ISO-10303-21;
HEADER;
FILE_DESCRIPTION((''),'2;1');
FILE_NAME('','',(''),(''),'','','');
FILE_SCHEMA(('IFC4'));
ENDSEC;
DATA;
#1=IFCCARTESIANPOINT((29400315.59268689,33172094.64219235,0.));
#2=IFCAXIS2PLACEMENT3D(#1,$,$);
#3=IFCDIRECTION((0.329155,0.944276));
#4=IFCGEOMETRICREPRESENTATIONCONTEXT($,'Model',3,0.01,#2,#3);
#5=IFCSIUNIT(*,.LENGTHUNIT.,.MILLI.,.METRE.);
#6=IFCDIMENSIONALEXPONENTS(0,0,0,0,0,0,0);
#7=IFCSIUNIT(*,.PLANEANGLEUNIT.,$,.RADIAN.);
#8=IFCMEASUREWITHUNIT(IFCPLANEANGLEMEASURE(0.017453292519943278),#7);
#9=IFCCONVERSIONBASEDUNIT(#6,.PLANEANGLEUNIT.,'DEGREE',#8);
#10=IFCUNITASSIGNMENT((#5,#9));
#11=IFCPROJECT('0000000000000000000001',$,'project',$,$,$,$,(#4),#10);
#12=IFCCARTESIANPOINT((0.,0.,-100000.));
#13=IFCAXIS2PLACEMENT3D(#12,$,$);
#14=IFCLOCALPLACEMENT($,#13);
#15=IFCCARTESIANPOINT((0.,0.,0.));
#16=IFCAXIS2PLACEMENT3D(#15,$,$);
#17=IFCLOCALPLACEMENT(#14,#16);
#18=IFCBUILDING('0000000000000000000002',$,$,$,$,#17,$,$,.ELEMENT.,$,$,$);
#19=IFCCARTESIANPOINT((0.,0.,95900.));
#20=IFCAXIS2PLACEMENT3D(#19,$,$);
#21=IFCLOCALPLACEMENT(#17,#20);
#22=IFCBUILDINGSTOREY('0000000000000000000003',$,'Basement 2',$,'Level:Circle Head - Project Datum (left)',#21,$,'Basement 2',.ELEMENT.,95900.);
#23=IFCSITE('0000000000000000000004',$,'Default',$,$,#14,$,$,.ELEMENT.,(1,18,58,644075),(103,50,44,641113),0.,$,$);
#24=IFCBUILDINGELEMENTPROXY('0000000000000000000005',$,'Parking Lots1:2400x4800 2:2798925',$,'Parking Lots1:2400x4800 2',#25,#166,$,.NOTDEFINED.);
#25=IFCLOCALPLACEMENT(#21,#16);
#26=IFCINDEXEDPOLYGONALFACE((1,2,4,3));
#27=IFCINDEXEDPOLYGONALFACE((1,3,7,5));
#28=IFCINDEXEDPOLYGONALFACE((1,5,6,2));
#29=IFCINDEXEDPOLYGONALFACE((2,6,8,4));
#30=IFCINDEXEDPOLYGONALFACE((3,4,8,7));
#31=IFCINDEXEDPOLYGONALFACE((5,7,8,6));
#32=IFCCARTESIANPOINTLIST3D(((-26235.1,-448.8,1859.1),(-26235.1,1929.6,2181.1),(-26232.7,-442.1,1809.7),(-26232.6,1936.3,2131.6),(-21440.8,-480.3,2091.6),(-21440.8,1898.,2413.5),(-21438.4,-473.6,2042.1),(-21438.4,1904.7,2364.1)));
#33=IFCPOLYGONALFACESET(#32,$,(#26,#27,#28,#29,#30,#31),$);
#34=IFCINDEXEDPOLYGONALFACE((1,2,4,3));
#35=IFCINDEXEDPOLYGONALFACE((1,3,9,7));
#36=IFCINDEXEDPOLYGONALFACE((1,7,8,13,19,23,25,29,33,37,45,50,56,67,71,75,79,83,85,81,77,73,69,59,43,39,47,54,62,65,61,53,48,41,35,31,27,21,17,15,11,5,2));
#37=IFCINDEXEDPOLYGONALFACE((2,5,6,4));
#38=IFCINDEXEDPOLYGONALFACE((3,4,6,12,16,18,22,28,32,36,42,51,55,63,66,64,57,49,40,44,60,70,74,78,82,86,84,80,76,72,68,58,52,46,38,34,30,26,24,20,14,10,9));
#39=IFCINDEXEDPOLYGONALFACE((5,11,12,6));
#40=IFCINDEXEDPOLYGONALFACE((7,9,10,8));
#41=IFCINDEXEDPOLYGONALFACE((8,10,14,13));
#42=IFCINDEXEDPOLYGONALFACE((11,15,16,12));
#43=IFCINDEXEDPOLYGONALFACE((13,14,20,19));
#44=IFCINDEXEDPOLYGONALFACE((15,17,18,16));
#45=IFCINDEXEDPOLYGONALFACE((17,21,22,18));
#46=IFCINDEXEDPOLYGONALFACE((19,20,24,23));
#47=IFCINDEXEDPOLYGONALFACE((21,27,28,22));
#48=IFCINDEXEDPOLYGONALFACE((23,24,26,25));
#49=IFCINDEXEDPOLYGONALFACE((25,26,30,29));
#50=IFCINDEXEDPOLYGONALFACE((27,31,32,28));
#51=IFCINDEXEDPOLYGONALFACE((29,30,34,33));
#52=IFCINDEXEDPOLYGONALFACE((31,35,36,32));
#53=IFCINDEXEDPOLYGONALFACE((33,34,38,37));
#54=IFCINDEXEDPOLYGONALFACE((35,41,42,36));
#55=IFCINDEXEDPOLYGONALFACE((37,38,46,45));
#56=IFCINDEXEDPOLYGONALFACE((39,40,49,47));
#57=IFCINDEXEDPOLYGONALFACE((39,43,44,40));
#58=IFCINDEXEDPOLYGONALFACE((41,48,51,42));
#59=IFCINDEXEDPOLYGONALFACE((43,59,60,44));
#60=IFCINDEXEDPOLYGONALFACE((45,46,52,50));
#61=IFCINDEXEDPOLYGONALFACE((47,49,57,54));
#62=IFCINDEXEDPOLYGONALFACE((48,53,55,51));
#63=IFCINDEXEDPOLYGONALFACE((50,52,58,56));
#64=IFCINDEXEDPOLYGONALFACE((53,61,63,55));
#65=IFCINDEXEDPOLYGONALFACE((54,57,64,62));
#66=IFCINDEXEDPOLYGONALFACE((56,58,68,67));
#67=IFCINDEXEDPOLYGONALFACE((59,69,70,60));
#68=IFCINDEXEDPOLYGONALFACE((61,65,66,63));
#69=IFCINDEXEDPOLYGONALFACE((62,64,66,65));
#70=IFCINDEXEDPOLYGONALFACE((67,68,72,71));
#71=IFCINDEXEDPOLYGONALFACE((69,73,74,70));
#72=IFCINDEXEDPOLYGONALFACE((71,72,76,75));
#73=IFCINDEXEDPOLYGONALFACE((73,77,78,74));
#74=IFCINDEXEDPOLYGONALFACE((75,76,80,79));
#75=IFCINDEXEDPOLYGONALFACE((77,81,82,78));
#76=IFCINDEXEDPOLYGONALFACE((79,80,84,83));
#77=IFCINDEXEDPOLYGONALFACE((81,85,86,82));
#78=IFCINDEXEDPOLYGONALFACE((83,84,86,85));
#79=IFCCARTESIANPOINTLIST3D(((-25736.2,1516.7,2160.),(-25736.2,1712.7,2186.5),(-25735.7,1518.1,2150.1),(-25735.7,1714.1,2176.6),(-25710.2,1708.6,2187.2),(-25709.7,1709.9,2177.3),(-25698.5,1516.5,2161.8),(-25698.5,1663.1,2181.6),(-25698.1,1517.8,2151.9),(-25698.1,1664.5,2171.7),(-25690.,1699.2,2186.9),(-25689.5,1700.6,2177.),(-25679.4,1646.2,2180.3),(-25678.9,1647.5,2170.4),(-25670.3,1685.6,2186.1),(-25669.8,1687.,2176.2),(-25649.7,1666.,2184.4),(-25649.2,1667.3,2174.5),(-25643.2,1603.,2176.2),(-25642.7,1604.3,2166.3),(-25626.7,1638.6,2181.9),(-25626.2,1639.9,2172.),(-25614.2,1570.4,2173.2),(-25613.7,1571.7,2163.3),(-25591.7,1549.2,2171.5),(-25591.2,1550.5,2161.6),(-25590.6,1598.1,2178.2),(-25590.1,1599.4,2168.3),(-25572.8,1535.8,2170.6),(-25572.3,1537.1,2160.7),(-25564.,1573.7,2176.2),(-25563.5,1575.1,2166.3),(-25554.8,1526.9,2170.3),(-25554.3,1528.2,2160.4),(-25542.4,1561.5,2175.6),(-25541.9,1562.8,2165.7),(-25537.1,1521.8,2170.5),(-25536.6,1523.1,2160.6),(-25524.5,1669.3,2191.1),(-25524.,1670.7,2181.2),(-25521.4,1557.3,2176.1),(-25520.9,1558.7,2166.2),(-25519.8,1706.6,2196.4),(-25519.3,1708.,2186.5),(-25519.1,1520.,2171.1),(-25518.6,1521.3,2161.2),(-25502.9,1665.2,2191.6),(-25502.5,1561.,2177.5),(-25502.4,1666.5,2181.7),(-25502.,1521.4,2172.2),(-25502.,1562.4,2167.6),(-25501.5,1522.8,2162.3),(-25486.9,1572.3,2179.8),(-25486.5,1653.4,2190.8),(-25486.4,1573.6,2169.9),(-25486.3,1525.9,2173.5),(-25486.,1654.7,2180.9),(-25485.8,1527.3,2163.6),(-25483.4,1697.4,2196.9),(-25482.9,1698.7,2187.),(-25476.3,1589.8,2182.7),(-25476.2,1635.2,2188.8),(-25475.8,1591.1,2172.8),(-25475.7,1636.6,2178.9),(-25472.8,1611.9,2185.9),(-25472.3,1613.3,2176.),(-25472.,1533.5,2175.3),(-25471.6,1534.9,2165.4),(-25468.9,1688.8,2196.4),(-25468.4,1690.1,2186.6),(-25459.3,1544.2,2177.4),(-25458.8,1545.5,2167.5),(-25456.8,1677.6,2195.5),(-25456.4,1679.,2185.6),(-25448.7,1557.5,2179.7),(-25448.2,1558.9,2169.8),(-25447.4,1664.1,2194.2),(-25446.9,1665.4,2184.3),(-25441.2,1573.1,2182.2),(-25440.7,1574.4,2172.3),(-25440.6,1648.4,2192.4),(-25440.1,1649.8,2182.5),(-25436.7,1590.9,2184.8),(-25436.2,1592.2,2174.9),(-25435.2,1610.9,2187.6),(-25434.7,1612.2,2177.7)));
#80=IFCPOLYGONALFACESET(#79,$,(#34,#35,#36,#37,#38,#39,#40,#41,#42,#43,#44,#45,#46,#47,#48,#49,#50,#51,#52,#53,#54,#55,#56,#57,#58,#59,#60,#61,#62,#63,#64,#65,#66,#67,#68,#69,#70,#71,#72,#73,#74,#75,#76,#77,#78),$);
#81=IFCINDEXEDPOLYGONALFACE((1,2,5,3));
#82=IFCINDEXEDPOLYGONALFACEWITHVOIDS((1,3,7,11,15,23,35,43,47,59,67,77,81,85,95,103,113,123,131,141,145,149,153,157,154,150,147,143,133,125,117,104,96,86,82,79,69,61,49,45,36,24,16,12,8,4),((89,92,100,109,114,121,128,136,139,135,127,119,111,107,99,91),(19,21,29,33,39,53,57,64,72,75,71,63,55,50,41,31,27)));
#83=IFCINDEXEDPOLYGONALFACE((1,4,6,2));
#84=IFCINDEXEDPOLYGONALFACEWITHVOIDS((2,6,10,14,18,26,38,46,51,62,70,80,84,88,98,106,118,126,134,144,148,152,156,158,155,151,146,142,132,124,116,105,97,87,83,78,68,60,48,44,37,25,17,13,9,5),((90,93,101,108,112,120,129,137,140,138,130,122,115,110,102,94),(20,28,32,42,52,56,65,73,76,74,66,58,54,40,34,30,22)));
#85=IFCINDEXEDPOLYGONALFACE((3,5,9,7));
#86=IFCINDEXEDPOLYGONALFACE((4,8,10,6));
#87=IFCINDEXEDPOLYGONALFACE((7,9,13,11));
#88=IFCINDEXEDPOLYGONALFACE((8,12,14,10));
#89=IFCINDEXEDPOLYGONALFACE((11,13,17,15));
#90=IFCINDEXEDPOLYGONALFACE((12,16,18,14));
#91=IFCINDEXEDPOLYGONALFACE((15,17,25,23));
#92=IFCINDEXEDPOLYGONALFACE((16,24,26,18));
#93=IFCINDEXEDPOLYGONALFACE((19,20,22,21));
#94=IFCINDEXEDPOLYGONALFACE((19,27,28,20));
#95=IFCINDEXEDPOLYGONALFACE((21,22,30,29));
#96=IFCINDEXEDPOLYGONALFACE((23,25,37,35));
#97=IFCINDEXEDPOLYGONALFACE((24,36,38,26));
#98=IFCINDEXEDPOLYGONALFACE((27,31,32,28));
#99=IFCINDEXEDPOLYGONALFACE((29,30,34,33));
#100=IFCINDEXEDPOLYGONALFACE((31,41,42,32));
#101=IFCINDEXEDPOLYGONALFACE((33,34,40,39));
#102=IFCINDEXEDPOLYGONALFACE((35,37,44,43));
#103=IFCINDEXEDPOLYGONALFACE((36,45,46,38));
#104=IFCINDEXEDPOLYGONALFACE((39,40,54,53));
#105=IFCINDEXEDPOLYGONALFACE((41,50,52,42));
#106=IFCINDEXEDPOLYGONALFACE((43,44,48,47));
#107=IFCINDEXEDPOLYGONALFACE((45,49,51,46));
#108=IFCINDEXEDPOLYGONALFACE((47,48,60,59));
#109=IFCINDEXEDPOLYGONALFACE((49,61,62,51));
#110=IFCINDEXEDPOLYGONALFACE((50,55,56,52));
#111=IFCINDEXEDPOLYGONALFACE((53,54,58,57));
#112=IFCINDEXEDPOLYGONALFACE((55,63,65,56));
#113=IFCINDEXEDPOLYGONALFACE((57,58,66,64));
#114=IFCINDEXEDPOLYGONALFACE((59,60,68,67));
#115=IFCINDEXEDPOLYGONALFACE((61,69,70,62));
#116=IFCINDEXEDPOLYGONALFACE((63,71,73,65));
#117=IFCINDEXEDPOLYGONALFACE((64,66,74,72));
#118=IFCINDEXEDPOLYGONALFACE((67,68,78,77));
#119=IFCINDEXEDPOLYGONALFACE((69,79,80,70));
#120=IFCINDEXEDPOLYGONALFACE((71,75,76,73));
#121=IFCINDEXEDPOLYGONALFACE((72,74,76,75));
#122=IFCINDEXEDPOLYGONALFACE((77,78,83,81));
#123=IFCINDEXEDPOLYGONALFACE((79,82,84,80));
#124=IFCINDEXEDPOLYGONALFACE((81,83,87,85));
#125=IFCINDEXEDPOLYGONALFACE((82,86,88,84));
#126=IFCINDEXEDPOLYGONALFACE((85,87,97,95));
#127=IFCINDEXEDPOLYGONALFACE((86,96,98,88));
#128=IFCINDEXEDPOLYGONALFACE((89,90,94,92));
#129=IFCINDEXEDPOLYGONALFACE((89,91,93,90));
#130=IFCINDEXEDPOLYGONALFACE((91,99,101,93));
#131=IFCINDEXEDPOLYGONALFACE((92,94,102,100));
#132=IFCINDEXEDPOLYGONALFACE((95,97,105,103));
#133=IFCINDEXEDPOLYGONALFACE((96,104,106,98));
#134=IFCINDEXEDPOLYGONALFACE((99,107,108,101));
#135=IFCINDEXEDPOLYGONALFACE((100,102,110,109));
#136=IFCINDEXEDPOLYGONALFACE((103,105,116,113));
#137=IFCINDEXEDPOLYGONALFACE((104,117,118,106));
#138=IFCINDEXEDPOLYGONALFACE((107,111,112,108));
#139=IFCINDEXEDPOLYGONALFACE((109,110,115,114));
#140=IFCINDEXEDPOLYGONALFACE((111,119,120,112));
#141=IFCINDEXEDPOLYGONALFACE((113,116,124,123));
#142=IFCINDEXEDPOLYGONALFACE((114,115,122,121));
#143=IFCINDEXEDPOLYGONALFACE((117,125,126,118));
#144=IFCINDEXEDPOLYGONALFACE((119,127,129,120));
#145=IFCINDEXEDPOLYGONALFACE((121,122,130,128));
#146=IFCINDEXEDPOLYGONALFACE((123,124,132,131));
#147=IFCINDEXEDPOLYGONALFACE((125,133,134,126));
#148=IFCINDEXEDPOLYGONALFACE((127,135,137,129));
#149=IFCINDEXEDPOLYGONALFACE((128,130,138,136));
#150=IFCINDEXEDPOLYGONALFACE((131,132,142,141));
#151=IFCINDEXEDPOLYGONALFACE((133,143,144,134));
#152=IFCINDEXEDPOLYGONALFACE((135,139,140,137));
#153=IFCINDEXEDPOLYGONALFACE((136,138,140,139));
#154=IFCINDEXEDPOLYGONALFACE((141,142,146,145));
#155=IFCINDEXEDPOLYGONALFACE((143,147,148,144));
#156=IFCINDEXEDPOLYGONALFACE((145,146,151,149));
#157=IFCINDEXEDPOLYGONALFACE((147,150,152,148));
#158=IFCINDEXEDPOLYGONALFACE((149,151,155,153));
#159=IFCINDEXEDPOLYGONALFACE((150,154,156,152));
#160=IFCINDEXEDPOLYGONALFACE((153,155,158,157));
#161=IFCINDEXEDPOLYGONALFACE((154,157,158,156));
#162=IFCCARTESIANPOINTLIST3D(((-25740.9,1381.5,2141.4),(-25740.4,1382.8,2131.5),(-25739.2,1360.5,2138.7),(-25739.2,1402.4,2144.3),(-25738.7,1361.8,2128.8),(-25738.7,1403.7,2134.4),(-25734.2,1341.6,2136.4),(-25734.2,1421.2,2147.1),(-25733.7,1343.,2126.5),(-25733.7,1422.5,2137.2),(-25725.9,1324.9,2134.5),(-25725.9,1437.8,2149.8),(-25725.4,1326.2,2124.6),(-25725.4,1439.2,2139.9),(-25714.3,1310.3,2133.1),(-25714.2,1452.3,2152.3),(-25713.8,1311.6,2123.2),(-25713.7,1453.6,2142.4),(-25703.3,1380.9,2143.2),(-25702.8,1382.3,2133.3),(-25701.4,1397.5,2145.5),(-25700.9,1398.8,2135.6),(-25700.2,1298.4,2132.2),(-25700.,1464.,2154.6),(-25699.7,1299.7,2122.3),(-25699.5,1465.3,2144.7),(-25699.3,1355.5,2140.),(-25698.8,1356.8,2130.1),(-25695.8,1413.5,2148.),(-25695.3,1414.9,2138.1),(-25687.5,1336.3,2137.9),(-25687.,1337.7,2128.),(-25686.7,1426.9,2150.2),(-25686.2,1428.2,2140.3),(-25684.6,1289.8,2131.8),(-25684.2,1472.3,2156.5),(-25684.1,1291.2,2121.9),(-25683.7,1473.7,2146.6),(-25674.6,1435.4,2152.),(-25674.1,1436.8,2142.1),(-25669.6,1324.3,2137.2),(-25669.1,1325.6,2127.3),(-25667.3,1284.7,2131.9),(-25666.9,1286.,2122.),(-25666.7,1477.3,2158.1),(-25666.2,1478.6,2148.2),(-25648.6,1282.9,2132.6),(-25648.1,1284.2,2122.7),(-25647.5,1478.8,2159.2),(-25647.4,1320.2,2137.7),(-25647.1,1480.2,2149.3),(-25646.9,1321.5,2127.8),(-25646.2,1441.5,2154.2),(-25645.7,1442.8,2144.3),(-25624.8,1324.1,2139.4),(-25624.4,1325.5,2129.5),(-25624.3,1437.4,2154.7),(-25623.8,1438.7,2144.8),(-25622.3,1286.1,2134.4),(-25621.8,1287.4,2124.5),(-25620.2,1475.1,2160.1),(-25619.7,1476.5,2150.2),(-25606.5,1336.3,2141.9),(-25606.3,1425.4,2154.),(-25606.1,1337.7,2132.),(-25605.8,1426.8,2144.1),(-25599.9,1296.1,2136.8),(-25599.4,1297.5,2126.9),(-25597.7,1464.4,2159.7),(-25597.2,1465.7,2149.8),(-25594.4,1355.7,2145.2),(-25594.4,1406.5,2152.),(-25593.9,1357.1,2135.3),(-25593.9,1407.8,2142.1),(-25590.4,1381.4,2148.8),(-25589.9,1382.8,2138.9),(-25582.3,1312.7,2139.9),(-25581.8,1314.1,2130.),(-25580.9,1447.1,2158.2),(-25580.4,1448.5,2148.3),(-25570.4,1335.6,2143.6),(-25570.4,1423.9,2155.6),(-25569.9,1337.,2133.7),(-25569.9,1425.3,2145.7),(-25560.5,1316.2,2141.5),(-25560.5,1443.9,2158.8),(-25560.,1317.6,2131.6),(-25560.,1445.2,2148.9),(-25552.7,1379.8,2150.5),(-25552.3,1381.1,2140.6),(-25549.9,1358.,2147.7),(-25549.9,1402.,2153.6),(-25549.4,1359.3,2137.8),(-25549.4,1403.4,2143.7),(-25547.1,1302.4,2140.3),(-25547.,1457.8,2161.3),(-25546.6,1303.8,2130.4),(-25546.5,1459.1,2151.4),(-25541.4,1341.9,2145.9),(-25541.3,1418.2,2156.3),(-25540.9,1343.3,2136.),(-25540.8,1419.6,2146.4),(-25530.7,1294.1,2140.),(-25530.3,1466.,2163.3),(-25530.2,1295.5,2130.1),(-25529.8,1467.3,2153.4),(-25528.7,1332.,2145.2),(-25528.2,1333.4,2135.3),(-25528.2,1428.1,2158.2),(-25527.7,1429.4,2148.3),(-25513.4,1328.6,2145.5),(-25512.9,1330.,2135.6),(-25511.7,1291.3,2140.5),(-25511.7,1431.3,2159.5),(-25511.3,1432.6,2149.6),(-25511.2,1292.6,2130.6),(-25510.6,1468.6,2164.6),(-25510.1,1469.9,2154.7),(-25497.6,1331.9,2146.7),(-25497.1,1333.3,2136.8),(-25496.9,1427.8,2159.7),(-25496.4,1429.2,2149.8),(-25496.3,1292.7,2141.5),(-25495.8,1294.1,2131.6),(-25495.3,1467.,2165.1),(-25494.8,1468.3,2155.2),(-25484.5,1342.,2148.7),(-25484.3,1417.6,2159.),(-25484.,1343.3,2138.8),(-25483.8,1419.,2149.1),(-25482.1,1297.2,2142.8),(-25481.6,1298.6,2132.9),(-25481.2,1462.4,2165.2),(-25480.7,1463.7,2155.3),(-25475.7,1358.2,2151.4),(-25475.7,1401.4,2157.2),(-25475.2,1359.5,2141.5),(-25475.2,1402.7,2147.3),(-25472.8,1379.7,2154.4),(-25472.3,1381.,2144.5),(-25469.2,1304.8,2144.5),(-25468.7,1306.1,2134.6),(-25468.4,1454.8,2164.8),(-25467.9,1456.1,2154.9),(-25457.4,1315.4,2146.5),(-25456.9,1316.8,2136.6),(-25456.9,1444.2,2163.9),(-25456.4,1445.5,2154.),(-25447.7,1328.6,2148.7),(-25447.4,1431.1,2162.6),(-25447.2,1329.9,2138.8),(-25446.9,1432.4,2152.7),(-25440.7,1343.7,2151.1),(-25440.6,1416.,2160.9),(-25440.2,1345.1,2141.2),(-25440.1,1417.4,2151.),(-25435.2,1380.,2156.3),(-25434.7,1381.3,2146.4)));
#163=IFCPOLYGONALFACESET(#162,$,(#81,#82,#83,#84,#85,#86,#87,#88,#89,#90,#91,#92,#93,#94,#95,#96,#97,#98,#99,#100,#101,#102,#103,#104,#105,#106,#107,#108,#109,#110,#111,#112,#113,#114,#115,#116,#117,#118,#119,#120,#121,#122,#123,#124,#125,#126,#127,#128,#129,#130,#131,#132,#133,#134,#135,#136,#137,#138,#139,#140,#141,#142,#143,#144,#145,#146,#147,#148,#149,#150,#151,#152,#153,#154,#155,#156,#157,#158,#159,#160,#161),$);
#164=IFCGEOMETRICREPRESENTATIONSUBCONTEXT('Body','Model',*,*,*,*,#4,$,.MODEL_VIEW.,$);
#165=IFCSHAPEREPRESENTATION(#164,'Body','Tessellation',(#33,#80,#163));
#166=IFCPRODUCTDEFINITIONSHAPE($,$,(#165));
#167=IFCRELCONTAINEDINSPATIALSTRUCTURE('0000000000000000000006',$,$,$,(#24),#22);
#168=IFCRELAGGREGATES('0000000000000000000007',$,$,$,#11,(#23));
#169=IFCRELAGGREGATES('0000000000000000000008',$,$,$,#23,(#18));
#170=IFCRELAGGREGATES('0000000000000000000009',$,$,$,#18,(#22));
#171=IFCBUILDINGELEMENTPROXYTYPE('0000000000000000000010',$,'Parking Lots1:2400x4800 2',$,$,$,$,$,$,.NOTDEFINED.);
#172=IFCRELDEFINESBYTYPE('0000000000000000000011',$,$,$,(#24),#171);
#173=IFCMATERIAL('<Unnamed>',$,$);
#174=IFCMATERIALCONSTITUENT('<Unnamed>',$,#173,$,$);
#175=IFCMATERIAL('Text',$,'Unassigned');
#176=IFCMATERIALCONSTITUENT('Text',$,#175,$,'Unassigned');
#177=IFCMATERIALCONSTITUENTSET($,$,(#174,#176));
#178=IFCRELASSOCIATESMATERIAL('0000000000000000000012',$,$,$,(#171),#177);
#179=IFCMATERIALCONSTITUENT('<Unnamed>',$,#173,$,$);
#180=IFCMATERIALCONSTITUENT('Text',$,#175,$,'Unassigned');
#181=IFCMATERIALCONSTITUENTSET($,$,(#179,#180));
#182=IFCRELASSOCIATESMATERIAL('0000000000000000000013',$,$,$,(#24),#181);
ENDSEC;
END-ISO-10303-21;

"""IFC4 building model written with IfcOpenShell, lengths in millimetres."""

from ifc_helpers import new_model, entity, si_unit, converted_unit, direction, frame, origin, place, context, subcontext, project, spatial, indexed_curve, outline, extrude, source, transform, mapped, material, constituent, constituent_set, type_object, type_shapes, element, save


model = new_model("IFC4")

# Units and contexts
model_context = context("Model", 3, precision=0.01, world=frame((29400315.59268689, 33172094.64219235, 0.0)), true_north=direction((0.329155, 0.944276)))
body_context = subcontext(model_context, "Body", "Model", "MODEL_VIEW")
ifc_project = project(units=[si_unit("LENGTHUNIT", "METRE", prefix="MILLI"), converted_unit("PLANEANGLEUNIT", "DEGREE", entity("IfcPlaneAngleMeasure", 0.017453292519943278), si_unit("PLANEANGLEUNIT", "RADIAN"), dimensions=[0, 0, 0, 0, 0, 0, 0])], contexts=[model_context])

# Site, building, storey
site_placement = place(None, frame((0.0, 0.0, -100000.0)))
site = spatial("IfcSite", under=ifc_project, at=site_placement, Name="Default", CompositionType="ELEMENT", RefLatitude=(1, 18, 58, 644075), RefLongitude=(103, 50, 44, 641113), RefElevation=0.0)
building_placement = place(site_placement, origin())
building = spatial("IfcBuilding", under=site, at=building_placement, CompositionType="ELEMENT")
storey_placement = place(building_placement, frame((0.0, 0.0, 95900.0)))
storey = spatial("IfcBuildingStorey", under=building, at=storey_placement, Name="Basement 2", ObjectType="Level:Circle Head - Project Datum (left)", LongName="Basement 2", CompositionType="ELEMENT", Elevation=95900.0)

# Shared definitions
ifc_material_1 = material(Name="<Unnamed>")

# Building element proxy
ifc_material_2 = material(Name="Text", Category="Unassigned")
ifc_constituent_1 = constituent(ifc_material_1, Name="<Unnamed>")
ifc_constituent_2 = constituent(ifc_material_2, Name="Text", Category="Unassigned")
ifc_constituent_set_1 = constituent_set(constituents=[ifc_constituent_1, ifc_constituent_2])
ifc_constituent_3 = constituent(ifc_material_1, Name="<Unnamed>")
ifc_constituent_4 = constituent(ifc_material_2, Name="Text", Category="Unassigned")
ifc_constituent_set_2 = constituent_set(constituents=[ifc_constituent_3, ifc_constituent_4])
building_element_proxy_type_1 = type_object("IfcBuildingElementProxyType", Name="Parking Lots1:2400x4800 2", PredefinedType="NOTDEFINED", material=ifc_constituent_set_2)
shared_shape_1 = source(origin(), body_context, "Body", "SweptSolid", [
    extrude(outline(indexed_curve([(-1200.0, -2400.0), (1200.0, -2400.0), (1200.0, 2400.0), (-1200.0, 2400.0), (-1200.0, -2400.0)], self_intersect=False)), frame((1200.0, -2400.0, 0.0), z_axis=(0.0, 0.0, 1.0), x_axis=(-1.0, 0.0, 0.0)), (0.0, 0.0, 1.0), 50.0),
    extrude(outline(indexed_curve([(-91.6, -150.5), (-91.6, -188.2), (106.2, -188.2), (102.1, -162.2), (92.9, -141.9), (79.3, -122.2), (59.6, -101.6), (32.1, -78.5), (-8.5, -42.4), (-32.9, -15.8), (-45.1, 5.8), (-49.2, 26.9), (-45.4, 45.8), (-33.9, 61.4), (-16.2, 72.0), (6.2, 75.5), (29.7, 72.1), (48.0, 61.8), (59.7, 45.4), (63.8, 23.7), (101.5, 28.4), (92.4, 64.9), (83.8, 79.4), (72.6, 91.5), (59.0, 101.0), (43.3, 107.8), (5.4, 113.2), (-14.8, 111.7), (-32.8, 107.2), (-48.5, 99.6), (-62.0, 89.1), (-72.9, 76.3), (-80.7, 62.0), (-85.3, 46.3), (-86.9, 29.2), (-85.2, 11.2), (-80.2, -6.5), (-71.3, -24.6), (-57.9, -43.5), (-36.6, -66.1), (-3.9, -95.1), (39.4, -131.3), (56.4, -150.5), (-91.6, -150.5)], self_intersect=False)), frame((320.3, -4111.8, 50.0), z_axis=(0.0, 0.0, -1.0), x_axis=(-1.0, 0.0, 0.0)), (0.0, 0.0, -1.0), 10.0),
    extrude(outline(indexed_curve([(33.1, -33.7), (58.7, -33.7), (81.4, -25.4), (100.4, -9.3), (114.8, 14.2), (121.1, 32.4), (123.6, 50.4), (122.4, 68.4), (117.3, 86.2), (108.7, 102.9), (96.8, 117.4), (81.5, 129.8), (62.9, 140.0), (43.0, 147.1), (23.6, 150.4), (4.8, 149.7), (-13.3, 145.1), (-30.0, 137.1), (-44.2, 126.3), (-55.9, 112.7), (-65.1, 96.3), (-72.8, 70.8), (-72.6, 46.2), (-64.4, 23.2), (-48.2, 2.8), (-70.0, 1.8), (-88.2, -4.8), (-102.4, -16.4), (-112.7, -32.6), (-117.6, -47.3), (-119.2, -62.1), (-117.5, -77.1), (-112.5, -92.3), (-104.3, -106.7), (-93.2, -119.3), (-62.1, -139.4), (-26.7, -149.3), (-10.1, -149.3), (5.8, -146.0), (20.3, -139.9), (32.4, -131.3), (42.4, -120.3), (50.0, -106.9), (55.6, -87.8), (54.8, -69.1), (47.4, -51.1), (33.1, -33.7)], self_intersect=False), holes=[indexed_curve([(16.1, -90.5), (6.9, -102.7), (-7.5, -110.0), (-26.0, -111.2), (-47.1, -104.8), (-65.7, -93.2), (-77.1, -78.5), (-81.0, -62.3), (-77.7, -46.5), (-68.4, -33.9), (-54.1, -26.4), (-35.9, -25.2), (-14.7, -31.6), (4.7, -43.5), (16.1, -58.0), (19.8, -74.1), (16.1, -90.5)], self_intersect=False), indexed_curve([(79.9, 28.5), (67.3, 10.0), (49.0, -1.4), (26.7, -4.6), (2.0, 2.2), (-20.0, 16.5), (-32.9, 35.6), (-36.7, 57.4), (-31.3, 79.7), (-18.5, 98.3), (-0.2, 109.8), (22.2, 112.7), (47.2, 105.8), (61.7, 97.2), (74.2, 85.4), (82.9, 71.6), (85.8, 56.9), (79.9, 28.5)], self_intersect=False)]), frame((548.5, -4151.2, 50.0), z_axis=(0.0, 0.0, 1.0), x_axis=(-0.912083, -0.410006, 0.0)), (0.0, 0.0, 1.0), 10.0),
])
type_shapes(building_element_proxy_type_1, [shared_shape_1])
proxy_1_placement = place(storey_placement, frame((-21438.4, 1904.7, 2364.1), z_axis=(-0.048866, -0.133991, 0.989777), x_axis=(-0.000014, -0.990961, -0.134152)))
element("IfcBuildingElementProxy", 1, at=proxy_1_placement, inside=storey, type_object=building_element_proxy_type_1, material=ifc_constituent_set_1, Name="Parking Lots1:2400x4800 2:2798925", ObjectType="Parking Lots1:2400x4800 2", PredefinedType="NOTDEFINED", context=body_context, shape_type="MappedRepresentation", body=[
    mapped(shared_shape_1, transform((0.0, 0.0, 0.0), scale=1.0)),
])

save(model, "model.ifc")
